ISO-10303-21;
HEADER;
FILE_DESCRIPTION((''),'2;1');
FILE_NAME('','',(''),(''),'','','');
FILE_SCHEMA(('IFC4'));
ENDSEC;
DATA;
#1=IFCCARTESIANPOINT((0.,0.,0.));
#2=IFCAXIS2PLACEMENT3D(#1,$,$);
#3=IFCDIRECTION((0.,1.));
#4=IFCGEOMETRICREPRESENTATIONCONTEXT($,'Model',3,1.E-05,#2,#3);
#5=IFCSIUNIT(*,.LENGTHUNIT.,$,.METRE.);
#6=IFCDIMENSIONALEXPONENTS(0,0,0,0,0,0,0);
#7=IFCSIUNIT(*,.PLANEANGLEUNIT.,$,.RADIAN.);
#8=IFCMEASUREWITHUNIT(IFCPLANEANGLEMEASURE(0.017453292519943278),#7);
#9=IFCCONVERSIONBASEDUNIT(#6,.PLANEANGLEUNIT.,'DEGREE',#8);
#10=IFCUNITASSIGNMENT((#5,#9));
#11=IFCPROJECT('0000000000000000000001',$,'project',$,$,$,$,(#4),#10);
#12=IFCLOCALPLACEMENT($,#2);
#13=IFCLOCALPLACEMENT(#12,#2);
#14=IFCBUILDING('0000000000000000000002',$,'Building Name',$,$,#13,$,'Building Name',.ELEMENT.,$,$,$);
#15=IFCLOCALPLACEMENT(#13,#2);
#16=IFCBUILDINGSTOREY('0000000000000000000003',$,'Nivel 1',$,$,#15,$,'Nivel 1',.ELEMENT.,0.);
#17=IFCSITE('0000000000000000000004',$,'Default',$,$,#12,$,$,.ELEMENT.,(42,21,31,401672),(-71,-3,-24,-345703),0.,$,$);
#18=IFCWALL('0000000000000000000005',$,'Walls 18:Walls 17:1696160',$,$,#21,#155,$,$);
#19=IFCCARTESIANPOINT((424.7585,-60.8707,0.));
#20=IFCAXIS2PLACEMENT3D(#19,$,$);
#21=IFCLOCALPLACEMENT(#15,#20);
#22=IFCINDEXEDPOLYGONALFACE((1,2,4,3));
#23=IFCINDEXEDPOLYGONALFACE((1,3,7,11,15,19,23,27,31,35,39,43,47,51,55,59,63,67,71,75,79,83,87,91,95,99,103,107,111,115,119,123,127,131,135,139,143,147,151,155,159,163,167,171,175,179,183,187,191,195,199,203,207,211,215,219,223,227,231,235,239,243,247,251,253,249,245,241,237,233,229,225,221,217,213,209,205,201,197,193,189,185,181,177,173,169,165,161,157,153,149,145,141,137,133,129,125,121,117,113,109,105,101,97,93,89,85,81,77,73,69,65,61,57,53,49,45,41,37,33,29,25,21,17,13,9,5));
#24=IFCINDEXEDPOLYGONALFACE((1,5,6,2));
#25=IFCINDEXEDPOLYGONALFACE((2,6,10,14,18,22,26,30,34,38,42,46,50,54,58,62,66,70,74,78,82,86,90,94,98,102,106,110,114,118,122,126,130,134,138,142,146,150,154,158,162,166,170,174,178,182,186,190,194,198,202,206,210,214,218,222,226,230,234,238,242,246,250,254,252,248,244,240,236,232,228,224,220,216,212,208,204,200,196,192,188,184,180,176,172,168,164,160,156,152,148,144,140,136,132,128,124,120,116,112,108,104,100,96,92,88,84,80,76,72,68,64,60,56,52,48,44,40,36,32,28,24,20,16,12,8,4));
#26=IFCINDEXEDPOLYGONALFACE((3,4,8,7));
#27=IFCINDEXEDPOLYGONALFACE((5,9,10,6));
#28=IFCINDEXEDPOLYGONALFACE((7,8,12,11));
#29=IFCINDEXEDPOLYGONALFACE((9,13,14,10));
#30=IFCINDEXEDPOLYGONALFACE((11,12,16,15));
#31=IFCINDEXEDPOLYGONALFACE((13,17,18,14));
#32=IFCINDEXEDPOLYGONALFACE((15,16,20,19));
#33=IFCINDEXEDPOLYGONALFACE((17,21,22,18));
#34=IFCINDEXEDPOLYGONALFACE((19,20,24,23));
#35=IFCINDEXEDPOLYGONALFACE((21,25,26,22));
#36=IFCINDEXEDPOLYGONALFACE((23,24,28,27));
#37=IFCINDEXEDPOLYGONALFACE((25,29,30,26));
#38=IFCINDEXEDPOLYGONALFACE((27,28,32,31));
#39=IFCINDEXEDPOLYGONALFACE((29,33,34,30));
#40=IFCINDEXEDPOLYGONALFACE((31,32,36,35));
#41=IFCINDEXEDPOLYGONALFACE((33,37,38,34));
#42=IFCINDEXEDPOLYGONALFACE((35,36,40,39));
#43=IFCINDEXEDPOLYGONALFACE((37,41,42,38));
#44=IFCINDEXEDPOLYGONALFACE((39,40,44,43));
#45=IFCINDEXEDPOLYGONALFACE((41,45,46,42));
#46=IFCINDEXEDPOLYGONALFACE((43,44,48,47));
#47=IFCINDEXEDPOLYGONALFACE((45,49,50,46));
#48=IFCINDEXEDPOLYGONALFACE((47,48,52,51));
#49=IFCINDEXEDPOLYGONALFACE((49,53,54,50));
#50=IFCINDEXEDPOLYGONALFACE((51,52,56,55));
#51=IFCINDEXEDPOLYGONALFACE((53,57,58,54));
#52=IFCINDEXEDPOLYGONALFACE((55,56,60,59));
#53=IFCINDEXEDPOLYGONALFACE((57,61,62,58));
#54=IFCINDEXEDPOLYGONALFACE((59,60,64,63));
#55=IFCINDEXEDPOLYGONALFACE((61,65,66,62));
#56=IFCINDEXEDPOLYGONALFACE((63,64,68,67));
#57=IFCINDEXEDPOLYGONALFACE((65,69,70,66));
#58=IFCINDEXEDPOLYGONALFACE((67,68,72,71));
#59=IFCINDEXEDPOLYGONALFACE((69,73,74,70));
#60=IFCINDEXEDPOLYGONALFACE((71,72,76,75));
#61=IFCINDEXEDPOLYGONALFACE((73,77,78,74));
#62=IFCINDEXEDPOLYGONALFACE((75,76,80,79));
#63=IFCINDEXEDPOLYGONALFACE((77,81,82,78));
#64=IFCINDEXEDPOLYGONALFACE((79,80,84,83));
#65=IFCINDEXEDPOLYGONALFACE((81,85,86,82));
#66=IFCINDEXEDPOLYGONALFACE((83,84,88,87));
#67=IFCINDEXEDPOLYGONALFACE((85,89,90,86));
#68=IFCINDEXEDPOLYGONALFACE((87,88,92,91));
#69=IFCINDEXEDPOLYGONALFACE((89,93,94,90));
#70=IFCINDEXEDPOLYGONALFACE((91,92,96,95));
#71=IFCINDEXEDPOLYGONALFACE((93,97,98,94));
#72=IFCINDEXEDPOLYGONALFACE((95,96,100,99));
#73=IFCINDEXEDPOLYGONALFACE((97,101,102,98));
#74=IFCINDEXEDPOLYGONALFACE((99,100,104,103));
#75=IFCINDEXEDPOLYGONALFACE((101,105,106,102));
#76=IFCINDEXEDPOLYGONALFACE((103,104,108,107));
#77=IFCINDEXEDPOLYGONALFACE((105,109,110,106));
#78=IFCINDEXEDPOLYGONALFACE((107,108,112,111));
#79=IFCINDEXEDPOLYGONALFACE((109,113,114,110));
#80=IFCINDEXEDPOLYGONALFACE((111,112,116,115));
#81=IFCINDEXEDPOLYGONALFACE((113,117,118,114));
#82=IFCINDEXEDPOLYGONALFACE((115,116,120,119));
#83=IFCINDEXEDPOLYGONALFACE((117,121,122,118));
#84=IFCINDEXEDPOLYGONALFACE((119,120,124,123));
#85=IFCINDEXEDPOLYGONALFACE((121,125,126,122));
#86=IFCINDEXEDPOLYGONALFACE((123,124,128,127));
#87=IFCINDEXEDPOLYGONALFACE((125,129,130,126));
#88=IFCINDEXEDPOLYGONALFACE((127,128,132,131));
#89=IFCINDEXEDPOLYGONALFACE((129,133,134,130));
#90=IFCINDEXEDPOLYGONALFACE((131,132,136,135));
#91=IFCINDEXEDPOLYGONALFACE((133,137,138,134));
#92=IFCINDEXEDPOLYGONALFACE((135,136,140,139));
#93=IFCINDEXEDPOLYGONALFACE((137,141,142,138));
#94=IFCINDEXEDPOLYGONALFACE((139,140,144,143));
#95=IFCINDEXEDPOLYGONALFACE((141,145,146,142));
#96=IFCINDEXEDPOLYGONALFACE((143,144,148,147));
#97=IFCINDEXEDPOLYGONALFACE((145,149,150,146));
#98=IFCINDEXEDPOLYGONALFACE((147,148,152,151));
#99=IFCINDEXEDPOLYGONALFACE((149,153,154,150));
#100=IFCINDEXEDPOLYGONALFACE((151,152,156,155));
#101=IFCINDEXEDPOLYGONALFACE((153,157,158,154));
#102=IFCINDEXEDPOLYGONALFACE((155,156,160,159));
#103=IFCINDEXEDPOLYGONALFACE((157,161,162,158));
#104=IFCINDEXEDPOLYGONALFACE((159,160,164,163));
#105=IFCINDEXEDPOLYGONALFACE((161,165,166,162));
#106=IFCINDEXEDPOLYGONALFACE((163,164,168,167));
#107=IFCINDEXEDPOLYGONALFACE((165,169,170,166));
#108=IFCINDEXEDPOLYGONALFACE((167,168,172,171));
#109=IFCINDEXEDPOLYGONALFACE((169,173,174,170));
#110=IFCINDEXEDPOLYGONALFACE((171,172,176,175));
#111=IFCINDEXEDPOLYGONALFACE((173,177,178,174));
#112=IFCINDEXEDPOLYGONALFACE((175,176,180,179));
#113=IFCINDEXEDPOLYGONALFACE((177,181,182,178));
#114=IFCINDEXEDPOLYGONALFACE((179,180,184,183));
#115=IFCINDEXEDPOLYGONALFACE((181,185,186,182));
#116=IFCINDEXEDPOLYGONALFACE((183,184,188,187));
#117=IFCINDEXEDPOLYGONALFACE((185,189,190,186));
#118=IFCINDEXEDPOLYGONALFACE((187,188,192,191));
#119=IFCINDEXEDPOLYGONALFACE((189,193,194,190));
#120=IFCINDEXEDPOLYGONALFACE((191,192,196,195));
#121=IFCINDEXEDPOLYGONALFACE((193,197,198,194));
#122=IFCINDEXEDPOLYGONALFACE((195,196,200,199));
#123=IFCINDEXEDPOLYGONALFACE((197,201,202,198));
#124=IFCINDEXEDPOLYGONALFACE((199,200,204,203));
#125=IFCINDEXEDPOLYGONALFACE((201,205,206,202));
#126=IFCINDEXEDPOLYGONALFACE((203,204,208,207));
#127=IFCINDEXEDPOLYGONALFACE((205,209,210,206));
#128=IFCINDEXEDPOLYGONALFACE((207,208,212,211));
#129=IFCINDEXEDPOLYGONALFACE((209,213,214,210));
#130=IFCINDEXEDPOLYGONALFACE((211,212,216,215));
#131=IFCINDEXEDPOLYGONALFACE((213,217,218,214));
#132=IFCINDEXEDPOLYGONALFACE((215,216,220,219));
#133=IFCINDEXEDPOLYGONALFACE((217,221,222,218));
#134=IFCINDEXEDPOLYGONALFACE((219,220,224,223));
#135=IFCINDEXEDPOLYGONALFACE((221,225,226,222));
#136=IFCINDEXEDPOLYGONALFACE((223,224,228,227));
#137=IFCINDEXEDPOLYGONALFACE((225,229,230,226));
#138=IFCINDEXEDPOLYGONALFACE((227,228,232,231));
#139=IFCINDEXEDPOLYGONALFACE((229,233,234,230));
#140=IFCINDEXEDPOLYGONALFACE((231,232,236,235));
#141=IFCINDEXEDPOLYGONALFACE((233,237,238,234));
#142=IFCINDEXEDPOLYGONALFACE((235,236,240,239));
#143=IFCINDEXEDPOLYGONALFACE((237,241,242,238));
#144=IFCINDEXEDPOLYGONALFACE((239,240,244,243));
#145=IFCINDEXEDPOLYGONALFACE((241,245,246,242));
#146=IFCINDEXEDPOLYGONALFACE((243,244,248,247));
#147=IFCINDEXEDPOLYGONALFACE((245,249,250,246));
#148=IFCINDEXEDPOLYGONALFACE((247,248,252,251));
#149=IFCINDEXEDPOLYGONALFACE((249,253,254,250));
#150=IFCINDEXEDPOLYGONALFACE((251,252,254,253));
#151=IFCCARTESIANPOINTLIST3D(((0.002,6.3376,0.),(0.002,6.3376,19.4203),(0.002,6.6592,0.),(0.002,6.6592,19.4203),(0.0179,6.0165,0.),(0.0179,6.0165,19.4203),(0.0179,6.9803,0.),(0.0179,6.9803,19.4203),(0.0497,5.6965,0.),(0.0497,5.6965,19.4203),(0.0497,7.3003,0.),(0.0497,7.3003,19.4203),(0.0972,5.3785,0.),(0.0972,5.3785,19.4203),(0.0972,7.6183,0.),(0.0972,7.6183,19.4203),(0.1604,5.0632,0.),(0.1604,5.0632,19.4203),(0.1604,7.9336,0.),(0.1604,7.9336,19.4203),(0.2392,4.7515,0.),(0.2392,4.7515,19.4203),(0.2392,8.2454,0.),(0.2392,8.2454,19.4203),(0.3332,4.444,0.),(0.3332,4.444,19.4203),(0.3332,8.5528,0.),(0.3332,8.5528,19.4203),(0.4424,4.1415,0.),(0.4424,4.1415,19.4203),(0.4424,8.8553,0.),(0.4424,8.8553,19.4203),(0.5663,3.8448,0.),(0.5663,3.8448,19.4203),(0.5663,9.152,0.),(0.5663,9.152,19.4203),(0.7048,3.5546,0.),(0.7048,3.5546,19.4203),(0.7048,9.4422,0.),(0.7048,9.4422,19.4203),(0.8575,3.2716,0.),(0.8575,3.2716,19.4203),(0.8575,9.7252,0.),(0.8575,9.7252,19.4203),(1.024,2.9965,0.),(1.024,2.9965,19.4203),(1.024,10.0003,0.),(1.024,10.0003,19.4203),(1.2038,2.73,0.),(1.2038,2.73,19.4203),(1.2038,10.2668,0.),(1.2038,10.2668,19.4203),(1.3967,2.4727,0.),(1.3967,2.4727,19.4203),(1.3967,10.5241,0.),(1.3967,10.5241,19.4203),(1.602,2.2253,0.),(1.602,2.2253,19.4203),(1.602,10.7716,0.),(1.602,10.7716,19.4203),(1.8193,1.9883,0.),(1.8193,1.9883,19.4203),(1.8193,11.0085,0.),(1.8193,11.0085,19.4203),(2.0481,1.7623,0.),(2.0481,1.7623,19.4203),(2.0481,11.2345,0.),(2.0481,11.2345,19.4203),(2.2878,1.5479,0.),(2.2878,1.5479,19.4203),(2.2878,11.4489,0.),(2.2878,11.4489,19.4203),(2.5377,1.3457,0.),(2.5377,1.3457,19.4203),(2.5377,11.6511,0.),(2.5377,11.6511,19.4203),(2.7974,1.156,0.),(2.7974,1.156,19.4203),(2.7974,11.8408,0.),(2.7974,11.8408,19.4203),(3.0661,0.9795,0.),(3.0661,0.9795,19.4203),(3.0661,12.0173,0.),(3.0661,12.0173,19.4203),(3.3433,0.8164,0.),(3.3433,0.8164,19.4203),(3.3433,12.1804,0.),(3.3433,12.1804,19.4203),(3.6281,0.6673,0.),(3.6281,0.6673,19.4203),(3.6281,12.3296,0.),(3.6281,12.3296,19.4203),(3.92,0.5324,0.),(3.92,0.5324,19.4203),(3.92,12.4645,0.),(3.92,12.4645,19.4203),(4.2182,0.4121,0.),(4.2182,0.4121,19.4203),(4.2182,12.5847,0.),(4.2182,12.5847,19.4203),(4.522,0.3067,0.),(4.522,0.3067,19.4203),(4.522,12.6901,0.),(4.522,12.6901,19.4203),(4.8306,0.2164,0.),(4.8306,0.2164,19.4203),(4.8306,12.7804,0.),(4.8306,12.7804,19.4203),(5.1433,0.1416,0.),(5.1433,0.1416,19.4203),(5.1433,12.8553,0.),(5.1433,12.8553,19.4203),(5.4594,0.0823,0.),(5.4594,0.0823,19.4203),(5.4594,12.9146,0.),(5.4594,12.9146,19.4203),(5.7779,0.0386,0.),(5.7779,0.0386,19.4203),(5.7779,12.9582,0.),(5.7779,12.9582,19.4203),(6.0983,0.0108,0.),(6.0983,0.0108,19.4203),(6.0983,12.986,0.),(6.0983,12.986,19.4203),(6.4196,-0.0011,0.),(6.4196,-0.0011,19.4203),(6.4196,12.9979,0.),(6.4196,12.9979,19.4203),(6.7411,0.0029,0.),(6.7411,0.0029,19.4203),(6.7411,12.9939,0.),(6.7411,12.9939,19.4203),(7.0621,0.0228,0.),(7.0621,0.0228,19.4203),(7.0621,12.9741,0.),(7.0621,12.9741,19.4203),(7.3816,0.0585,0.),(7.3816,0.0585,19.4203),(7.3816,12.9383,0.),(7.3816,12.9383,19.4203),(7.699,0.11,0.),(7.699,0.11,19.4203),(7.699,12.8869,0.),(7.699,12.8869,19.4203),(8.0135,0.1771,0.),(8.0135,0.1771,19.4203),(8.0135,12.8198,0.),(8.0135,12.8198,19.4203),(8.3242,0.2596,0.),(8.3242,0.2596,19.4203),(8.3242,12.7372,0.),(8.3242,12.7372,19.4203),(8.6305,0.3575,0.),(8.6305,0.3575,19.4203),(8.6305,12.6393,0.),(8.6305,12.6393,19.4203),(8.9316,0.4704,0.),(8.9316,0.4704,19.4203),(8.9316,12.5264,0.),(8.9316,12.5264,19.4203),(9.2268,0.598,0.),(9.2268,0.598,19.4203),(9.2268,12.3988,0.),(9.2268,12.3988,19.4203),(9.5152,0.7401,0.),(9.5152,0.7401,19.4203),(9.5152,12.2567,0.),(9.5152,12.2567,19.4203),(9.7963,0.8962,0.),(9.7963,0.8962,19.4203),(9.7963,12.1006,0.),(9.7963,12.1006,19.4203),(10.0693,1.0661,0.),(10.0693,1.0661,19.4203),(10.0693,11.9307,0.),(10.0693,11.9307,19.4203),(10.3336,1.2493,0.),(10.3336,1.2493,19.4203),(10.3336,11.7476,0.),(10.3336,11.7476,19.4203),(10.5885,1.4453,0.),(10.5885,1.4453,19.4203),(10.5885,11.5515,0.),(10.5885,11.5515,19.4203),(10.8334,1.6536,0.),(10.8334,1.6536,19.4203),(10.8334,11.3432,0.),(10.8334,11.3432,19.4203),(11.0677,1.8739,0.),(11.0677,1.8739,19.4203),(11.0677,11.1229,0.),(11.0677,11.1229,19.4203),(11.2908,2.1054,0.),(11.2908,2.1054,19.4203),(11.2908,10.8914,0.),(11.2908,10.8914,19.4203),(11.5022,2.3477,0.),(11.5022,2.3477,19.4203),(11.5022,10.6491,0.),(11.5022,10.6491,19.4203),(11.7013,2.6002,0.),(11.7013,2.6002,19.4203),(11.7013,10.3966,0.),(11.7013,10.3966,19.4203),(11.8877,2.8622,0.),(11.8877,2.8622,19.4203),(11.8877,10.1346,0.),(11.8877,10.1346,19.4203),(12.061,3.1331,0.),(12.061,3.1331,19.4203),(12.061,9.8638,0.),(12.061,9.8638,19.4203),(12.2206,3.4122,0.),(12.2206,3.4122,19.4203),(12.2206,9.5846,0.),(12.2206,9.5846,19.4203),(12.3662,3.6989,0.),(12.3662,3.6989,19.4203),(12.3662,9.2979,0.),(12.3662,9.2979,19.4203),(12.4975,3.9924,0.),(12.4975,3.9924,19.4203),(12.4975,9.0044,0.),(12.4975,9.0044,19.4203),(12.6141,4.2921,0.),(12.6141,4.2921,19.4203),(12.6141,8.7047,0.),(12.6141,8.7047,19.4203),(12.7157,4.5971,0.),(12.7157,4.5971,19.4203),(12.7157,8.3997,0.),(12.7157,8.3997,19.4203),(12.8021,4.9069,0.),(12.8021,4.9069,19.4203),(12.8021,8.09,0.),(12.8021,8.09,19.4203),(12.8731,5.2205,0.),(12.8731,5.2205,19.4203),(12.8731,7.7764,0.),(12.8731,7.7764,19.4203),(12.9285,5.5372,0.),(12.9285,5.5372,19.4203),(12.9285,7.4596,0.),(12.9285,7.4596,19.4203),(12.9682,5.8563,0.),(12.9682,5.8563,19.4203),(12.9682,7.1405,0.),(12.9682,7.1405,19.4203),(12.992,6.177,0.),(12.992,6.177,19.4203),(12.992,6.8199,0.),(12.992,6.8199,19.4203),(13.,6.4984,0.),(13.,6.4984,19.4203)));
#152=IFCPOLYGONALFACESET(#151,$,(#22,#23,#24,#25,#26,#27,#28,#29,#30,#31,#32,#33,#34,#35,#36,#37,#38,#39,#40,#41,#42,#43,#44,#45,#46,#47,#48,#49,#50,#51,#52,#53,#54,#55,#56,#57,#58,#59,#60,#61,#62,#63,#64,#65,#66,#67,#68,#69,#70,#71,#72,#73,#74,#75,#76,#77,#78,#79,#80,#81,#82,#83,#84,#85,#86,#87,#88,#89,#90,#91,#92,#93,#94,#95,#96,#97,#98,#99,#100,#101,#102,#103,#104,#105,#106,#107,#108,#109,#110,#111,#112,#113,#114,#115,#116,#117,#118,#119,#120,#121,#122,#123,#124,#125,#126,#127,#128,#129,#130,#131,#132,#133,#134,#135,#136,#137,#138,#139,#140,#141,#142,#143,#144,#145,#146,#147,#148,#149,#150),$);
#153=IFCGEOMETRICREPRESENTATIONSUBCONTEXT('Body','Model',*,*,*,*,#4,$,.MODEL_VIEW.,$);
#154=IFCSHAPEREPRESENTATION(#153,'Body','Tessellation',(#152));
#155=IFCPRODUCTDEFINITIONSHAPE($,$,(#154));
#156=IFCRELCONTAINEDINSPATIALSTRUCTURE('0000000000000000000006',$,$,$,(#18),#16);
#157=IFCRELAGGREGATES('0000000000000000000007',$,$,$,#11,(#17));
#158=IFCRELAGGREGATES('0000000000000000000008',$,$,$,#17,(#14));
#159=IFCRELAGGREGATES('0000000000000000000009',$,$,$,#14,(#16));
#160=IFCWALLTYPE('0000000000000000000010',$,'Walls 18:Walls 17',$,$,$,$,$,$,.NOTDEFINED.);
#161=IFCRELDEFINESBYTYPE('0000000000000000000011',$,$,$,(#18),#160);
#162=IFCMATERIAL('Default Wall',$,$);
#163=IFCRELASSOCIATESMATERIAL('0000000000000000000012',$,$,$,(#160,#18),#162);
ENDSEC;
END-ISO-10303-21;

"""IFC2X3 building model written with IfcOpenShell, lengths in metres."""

from ifc_helpers import new_model, entity, si_unit, converted_unit, direction, frame, frame_2d, origin, place, context, subcontext, project, spatial, circle, extrude, material, type_object, element, save


model = new_model("IFC2X3")

# Units and contexts
model_context = context("Model", 3, precision=1e-05, world=origin(), true_north=direction((0.0, 1.0)))
body_context = subcontext(model_context, "Body", "Model", "MODEL_VIEW")
ifc_project = project(units=[si_unit("LENGTHUNIT", "METRE"), converted_unit("PLANEANGLEUNIT", "DEGREE", entity("IfcPlaneAngleMeasure", 0.017453292519943278), si_unit("PLANEANGLEUNIT", "RADIAN"), dimensions=[0, 0, 0, 0, 0, 0, 0])], contexts=[model_context])

# Site, building, storey
site_placement = place(None, origin())
site = spatial("IfcSite", under=ifc_project, at=site_placement, Name="Default", CompositionType="ELEMENT", RefLatitude=(42, 21, 31, 401672), RefLongitude=(-71, -3, -24, -345703), RefElevation=0.0)
building_placement = place(site_placement, origin())
building = spatial("IfcBuilding", under=site, at=building_placement, Name="Building Name", LongName="Building Name", CompositionType="ELEMENT")
storey_placement = place(building_placement, origin())
storey = spatial("IfcBuildingStorey", under=building, at=storey_placement, Name="Nivel 1", LongName="Nivel 1", CompositionType="ELEMENT", Elevation=0.0)

# Wall
ifc_material_1 = material(Name="Default Wall")
wall_type_1 = type_object("IfcWallType", Name="Walls 18:Walls 17", PredefinedType="NOTDEFINED", material=ifc_material_1)
wall_1_placement = place(storey_placement, frame((424.7585, -60.8707, 0.0)))
element("IfcWall", 1, at=wall_1_placement, inside=storey, type_object=wall_type_1, material=ifc_material_1, Name="Walls 18:Walls 17:1696160", context=body_context, shape_type="SweptSolid", body=[
    extrude(circle(Radius=6.5, at=frame_2d((0.0, 0.0), x_axis=(1.0, 0.0))), frame((6.5, 6.4984, 0.0)), (0.0, 0.0, 1.0), 19.4203),
])

save(model, "model.ifc")
